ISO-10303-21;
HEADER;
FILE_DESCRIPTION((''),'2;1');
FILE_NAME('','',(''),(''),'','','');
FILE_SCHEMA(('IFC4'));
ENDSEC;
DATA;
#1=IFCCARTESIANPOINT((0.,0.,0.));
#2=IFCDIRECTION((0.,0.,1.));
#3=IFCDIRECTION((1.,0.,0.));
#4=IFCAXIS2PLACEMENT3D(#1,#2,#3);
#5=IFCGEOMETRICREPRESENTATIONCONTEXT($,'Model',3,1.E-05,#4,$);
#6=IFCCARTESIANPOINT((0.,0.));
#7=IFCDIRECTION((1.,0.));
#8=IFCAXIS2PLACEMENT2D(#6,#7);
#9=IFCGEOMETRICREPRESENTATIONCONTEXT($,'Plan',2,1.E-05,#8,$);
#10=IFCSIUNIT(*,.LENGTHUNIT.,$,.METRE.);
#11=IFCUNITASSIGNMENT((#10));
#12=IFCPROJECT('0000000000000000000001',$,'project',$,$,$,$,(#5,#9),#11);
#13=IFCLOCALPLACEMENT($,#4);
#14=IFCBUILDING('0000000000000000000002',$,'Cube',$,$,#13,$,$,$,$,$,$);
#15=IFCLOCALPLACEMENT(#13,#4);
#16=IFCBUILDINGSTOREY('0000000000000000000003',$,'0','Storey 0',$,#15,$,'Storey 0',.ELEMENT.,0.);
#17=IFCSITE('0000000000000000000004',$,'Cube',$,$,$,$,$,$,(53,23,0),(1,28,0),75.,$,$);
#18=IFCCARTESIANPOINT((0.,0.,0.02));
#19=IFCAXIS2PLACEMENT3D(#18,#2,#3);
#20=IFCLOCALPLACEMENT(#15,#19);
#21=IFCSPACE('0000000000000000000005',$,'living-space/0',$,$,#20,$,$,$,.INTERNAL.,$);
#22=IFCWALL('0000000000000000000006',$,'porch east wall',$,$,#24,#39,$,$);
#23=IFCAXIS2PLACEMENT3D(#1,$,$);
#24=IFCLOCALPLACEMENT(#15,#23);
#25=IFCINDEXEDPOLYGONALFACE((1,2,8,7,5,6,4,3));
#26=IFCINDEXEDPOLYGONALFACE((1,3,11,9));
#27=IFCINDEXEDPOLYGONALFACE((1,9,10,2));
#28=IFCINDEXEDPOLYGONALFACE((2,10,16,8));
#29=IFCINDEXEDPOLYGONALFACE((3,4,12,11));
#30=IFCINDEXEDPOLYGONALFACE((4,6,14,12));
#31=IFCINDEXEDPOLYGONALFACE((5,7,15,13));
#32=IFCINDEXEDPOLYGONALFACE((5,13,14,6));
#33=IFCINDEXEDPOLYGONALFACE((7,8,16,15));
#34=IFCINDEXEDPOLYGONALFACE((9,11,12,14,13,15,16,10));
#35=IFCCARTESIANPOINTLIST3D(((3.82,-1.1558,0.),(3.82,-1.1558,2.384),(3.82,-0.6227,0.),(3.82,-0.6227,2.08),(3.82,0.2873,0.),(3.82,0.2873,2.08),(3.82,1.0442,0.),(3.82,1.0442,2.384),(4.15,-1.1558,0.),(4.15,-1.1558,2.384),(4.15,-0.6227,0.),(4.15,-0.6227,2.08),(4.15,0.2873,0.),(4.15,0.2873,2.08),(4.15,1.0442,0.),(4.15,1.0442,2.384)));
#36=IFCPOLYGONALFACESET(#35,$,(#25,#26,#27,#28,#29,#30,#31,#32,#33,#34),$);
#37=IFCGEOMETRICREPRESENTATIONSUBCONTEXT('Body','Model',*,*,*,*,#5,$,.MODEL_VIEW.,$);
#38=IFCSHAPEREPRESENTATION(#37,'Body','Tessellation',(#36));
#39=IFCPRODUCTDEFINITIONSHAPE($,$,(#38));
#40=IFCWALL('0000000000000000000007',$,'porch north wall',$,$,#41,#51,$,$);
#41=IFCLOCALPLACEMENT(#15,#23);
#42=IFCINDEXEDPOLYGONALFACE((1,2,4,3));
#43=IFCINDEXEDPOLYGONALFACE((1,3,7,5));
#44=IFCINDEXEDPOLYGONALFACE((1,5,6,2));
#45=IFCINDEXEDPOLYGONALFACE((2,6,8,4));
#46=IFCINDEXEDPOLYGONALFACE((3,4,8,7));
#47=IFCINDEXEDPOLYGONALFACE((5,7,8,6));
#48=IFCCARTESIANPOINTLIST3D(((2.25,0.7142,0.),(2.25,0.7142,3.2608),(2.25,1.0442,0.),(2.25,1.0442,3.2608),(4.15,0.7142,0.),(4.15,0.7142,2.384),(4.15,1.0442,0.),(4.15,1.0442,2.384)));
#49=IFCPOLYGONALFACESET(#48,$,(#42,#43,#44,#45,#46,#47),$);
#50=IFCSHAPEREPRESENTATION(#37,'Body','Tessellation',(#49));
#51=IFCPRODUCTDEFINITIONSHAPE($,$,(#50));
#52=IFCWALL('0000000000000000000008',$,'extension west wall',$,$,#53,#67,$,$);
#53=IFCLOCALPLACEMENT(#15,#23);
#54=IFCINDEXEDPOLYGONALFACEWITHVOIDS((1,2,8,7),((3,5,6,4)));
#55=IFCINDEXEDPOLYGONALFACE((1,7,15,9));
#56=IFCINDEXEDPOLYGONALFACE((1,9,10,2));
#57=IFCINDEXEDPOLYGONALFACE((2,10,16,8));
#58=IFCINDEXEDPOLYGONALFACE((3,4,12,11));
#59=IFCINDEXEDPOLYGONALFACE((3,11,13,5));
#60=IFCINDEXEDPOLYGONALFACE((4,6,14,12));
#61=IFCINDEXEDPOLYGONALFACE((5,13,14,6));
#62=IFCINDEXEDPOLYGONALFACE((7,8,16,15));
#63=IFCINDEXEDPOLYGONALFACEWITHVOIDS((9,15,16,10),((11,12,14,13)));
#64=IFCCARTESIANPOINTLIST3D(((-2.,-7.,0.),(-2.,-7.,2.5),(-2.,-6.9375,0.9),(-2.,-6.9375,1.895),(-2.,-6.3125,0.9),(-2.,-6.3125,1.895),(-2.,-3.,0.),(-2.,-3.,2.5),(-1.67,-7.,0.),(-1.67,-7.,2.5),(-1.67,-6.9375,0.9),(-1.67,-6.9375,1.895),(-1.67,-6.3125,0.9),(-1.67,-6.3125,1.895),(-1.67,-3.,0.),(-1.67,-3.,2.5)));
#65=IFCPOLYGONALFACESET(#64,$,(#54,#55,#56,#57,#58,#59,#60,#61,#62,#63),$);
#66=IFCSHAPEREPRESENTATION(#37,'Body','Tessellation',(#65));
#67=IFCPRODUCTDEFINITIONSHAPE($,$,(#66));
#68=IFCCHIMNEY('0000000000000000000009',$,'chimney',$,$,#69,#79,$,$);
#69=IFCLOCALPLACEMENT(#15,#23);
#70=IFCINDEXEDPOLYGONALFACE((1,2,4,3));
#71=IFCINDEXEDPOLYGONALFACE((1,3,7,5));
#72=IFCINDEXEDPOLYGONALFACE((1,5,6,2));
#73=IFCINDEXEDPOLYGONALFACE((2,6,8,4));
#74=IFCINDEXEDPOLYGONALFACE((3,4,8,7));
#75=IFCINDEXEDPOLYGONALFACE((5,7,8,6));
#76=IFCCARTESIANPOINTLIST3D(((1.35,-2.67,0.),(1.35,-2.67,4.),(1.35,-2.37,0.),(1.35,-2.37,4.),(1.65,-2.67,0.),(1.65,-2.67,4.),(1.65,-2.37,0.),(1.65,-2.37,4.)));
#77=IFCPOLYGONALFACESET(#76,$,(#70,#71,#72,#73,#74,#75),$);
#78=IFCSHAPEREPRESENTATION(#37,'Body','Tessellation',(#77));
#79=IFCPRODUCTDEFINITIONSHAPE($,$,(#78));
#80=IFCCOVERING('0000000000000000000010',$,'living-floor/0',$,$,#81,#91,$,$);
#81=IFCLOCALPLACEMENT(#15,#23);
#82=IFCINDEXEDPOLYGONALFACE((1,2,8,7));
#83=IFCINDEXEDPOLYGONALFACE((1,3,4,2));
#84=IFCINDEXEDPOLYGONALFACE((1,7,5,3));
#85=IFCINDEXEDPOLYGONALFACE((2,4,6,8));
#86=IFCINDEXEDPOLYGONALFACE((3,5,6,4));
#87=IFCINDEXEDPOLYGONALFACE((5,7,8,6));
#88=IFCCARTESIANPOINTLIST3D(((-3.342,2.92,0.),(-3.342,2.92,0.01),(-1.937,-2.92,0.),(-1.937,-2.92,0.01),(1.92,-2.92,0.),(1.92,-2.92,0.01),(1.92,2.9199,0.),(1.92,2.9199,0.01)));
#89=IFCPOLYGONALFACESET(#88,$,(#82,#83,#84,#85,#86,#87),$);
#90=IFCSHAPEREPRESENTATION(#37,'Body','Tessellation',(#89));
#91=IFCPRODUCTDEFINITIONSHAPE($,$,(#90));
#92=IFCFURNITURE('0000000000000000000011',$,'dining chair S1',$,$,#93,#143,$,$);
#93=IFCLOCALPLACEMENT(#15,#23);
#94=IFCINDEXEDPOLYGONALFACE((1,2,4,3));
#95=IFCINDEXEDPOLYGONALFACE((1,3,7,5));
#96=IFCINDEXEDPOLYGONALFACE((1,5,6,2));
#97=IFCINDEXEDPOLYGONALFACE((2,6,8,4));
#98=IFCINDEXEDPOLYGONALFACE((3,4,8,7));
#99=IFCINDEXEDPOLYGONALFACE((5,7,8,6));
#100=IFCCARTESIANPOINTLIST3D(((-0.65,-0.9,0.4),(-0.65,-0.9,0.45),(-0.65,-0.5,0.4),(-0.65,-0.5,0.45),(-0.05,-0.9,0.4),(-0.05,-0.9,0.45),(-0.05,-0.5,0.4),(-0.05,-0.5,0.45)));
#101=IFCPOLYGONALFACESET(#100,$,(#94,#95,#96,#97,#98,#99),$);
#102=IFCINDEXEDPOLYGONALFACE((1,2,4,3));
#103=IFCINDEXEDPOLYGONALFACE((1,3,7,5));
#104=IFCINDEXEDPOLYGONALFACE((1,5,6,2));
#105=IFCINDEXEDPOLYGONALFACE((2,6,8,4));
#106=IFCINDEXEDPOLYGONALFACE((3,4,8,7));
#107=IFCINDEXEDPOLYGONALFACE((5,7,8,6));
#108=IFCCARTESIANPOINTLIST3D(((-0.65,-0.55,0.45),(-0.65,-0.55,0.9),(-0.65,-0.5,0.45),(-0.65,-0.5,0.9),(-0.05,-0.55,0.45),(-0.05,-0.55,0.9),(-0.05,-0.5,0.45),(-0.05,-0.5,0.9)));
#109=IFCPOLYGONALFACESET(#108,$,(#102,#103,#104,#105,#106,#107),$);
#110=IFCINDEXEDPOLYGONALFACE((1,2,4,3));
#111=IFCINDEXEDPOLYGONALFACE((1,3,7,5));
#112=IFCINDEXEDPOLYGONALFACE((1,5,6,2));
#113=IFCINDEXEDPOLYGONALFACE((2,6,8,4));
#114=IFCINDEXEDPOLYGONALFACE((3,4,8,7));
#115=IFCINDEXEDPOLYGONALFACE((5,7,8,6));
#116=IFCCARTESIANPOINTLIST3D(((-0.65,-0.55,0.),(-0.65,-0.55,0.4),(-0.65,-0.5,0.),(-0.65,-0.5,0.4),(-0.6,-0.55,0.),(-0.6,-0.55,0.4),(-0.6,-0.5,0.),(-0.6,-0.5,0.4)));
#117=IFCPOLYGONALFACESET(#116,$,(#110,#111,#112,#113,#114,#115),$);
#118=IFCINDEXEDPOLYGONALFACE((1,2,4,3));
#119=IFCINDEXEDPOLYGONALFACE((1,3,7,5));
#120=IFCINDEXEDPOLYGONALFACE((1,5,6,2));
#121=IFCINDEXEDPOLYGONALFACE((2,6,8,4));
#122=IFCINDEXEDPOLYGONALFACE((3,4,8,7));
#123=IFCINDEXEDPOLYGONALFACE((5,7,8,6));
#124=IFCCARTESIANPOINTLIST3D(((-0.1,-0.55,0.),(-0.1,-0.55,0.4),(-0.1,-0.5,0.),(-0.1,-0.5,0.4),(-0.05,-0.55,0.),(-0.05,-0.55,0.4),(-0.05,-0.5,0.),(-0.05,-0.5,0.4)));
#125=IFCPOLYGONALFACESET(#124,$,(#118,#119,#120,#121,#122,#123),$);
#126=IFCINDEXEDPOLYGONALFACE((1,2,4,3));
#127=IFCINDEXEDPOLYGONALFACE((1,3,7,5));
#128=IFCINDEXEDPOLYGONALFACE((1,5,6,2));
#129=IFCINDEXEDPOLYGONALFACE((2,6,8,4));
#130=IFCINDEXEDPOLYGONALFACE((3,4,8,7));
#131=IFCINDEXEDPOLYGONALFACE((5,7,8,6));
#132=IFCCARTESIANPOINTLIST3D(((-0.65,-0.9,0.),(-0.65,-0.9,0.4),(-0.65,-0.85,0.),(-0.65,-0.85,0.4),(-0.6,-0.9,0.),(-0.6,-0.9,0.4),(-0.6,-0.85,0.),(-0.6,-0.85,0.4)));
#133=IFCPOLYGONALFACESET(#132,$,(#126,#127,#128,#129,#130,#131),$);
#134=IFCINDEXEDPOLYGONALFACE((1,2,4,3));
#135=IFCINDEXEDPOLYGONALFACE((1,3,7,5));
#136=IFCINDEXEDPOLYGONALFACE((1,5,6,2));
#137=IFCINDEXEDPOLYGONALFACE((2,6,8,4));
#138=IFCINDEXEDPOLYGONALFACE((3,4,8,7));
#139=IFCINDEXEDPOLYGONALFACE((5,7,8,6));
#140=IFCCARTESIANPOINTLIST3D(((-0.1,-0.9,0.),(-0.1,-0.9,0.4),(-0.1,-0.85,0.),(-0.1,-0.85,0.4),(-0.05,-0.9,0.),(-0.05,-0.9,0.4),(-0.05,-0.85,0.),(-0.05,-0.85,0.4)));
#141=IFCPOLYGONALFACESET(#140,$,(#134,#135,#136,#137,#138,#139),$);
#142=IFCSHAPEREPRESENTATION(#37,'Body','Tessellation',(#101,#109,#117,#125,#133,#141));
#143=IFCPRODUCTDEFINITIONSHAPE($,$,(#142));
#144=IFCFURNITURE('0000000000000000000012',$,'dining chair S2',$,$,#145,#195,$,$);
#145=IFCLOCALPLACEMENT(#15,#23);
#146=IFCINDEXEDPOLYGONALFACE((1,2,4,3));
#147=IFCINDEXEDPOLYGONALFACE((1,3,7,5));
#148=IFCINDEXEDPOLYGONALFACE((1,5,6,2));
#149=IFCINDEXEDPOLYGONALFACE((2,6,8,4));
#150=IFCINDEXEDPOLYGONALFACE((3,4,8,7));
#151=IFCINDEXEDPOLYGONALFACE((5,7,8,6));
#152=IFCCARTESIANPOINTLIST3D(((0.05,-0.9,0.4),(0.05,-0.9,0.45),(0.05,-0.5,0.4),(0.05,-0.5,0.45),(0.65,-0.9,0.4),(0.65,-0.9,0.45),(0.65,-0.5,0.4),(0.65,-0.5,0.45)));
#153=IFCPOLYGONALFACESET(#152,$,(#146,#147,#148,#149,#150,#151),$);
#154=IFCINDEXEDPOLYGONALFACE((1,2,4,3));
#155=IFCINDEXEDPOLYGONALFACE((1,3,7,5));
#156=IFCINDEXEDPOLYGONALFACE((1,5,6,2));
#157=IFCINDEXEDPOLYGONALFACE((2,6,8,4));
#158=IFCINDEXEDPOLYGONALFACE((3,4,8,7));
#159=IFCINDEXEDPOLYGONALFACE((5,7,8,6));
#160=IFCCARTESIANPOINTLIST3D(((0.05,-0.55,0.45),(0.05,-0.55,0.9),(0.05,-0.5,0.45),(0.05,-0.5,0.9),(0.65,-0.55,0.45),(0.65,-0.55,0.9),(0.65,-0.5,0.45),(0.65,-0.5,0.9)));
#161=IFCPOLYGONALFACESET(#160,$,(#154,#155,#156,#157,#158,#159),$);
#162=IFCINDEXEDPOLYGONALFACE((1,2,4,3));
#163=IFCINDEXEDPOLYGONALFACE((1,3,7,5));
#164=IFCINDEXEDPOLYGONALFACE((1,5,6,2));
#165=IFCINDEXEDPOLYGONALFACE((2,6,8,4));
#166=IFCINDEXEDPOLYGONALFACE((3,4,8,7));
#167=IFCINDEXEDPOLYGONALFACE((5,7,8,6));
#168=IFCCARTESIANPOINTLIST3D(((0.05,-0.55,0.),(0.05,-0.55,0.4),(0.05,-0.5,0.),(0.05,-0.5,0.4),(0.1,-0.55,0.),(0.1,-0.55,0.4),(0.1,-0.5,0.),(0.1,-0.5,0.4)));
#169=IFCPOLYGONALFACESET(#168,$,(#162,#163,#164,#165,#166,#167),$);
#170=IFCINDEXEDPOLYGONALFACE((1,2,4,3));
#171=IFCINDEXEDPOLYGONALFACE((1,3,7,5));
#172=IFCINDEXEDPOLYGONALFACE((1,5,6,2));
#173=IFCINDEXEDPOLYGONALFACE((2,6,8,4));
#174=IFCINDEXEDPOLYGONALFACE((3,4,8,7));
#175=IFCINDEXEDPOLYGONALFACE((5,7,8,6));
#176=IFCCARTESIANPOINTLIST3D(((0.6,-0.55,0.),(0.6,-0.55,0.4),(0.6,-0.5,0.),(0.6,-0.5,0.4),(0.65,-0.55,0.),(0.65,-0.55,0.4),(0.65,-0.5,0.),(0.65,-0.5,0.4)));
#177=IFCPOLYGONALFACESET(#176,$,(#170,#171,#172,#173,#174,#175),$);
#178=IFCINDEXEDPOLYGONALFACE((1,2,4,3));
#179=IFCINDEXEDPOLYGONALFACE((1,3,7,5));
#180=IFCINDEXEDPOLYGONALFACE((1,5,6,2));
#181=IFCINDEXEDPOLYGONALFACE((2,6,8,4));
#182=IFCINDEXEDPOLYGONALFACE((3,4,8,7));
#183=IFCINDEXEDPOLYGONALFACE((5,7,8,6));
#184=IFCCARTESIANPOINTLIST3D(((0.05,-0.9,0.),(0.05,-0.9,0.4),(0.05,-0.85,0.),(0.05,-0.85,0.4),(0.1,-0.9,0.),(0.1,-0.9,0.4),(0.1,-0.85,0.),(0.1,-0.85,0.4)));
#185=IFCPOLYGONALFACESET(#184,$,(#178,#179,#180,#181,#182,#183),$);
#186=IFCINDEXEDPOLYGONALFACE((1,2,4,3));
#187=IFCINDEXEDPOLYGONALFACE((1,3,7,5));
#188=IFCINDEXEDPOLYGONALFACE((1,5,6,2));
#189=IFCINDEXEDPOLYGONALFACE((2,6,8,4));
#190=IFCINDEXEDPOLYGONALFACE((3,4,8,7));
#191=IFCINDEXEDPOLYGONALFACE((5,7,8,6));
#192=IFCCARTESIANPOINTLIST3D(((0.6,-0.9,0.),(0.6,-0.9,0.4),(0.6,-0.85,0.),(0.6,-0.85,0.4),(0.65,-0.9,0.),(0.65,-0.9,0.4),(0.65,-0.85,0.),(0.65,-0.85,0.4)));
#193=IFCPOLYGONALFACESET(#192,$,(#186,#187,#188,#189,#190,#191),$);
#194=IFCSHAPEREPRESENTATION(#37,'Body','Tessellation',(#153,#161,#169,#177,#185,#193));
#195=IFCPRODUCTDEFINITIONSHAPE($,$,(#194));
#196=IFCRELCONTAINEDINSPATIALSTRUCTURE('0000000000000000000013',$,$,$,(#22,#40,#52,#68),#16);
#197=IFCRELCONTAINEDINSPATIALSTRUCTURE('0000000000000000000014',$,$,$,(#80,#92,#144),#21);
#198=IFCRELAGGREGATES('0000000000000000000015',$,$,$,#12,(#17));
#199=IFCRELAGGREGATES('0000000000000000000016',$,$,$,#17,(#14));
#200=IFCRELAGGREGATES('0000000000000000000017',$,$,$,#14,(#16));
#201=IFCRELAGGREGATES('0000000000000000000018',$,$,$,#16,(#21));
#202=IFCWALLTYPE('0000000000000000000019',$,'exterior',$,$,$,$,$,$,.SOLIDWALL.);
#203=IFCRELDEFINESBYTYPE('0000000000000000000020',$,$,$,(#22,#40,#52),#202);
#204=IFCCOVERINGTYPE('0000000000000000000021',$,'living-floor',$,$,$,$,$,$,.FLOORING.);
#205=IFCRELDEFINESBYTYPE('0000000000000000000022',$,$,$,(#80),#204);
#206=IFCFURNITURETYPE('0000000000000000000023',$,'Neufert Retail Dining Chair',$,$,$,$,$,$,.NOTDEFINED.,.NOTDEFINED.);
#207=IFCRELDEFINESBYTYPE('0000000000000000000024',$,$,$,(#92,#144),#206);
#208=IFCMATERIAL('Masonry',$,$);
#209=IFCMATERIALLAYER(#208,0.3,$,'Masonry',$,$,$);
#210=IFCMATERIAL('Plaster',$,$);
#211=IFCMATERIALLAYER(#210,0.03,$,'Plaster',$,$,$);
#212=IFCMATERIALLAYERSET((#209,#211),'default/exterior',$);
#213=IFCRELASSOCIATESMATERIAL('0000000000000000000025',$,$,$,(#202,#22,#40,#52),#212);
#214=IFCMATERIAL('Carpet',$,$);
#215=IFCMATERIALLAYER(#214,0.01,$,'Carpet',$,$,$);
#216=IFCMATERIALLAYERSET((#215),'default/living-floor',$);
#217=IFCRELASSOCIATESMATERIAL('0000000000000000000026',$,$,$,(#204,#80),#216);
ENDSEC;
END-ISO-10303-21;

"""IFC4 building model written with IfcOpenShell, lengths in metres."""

from ifc_helpers import new_model, entity, si_unit, frame, origin_with_axes, origin_2d_with_axis, place, context, subcontext, project, spatial, polyline, line, indexed_curve, outline, extrude, clip, halfspace, shape, source, transform, mapped, material, layer, layer_set, layer_usage, type_object, type_shapes, element, save


model = new_model("IFC4")

# Units and contexts
model_context = context("Model", 3, precision=1e-05, world=origin_with_axes())
plan_context = context("Plan", 2, precision=1e-05, world=origin_2d_with_axis())
body_context_1 = subcontext(model_context, "Body", "Model", "MODEL_VIEW")
body_context_2 = subcontext(plan_context, "Body", "Plan", "PLAN_VIEW")
ifc_project = project(units=[si_unit("LENGTHUNIT", "METRE")], contexts=[model_context, plan_context])

# Site, building, storey
site = spatial("IfcSite", under=ifc_project, Name="Cube", RefLatitude=(53, 23, 0), RefLongitude=(1, 28, 0), RefElevation=75.0)
building_placement = place(None, origin_with_axes())
building = spatial("IfcBuilding", under=site, at=building_placement, Name="Cube")
storey_placement = place(building_placement, origin_with_axes())
storey = spatial("IfcBuildingStorey", under=building, at=storey_placement, Name="0", Description="Storey 0", LongName="Storey 0", CompositionType="ELEMENT", Elevation=0.0)

# Shared definitions
ifc_material_1 = material(Name="Masonry")
ifc_layer_1 = layer(ifc_material_1, 0.3, Name="Masonry")
ifc_material_2 = material(Name="Plaster")
ifc_layer_2 = layer(ifc_material_2, 0.03, Name="Plaster")
ifc_layer_set_1 = layer_set([ifc_layer_1, ifc_layer_2], Name="default/exterior")
wall_type = type_object("IfcWallType", Name="exterior", PredefinedType="SOLIDWALL", material=ifc_layer_set_1)

# Wall, opening
ifc_layer_usage_1 = layer_usage(ifc_layer_set_1, "AXIS2", "POSITIVE", 0.0)
wall_1_placement = place(storey_placement, frame((4.15, -1.1558, 0.0), z_axis=(0.0, 0.0, 1.0), x_axis=(0.0, 1.0, 0.0)))
wall_1 = element("IfcWall", 1, at=wall_1_placement, inside=storey, type_object=wall_type, material=ifc_layer_usage_1, Name="porch east wall", context=body_context_1, shape_type="SweptSolid", body=[
    extrude(outline(indexed_curve([(0.0, 0.0), (0.0, 0.33), (2.2, 0.33), (2.2, 0.0), (0.0, 0.0)], self_intersect=False)), origin_with_axes(), (0.0, 0.0, 1.0), 2.384),
])
shared_shape_1 = source(origin_with_axes(), body_context_1, "Body", "SweptSolid", [
    extrude(outline(indexed_curve([(0.0, 0.0), (0.91, 0.0), (0.91, 2.08), (0.0, 2.08)], segments=[line(1, 2, 3, 4, 1)])), frame((0.0, -0.6, 0.0), z_axis=(0.0, -1.0, 0.0), x_axis=(1.0, 0.0, 0.0)), (0.0, 0.0, -1.0), 1.2),
])
opening_1_placement = place(wall_1_placement, frame((0.5331, 0.0, 0.0), z_axis=(0.0, 0.0, 1.0), x_axis=(1.0, 0.0, 0.0)))
element("IfcOpeningElement", 2, at=opening_1_placement, cuts=wall_1, PredefinedType="OPENING", context=body_context_1, shape_type="MappedRepresentation", body=[
    mapped(shared_shape_1, transform((0.0, 0.0, 0.0), x_axis=(1.0, 0.0, 0.0), y_axis=(0.0, 1.0, 0.0), z_axis=(0.0, 0.0, 1.0), scale=1.0)),
])

# Wall
ifc_layer_usage_2 = layer_usage(ifc_layer_set_1, "AXIS2", "POSITIVE", 0.0)
wall_2_placement = place(storey_placement, frame((4.15, 1.0442, 0.0), z_axis=(0.0, 0.0, 1.0), x_axis=(-1.0, 0.0, 0.0)))
element("IfcWall", 3, at=wall_2_placement, inside=storey, type_object=wall_type, material=ifc_layer_usage_2, Name="porch north wall", context=body_context_1, shape_type="Clipping", body=[
    clip(extrude(outline(indexed_curve([(0.0, 0.0), (0.0, 0.33), (1.9, 0.33), (1.9, 0.0), (0.0, 0.0)], self_intersect=False)), origin_with_axes(), (0.0, 0.0, 1.0), 3.5), halfspace(frame((0.0, 0.0, 2.384), z_axis=(-0.419, 0.0, 0.908), x_axis=(0.0, -1.0, 0.0)), False)),
])

# Wall, opening
ifc_layer_usage_3 = layer_usage(ifc_layer_set_1, "AXIS2", "POSITIVE", 0.0)
wall_3_placement = place(storey_placement, frame((-2.0, -3.0, 0.0), z_axis=(0.0, 0.0, 1.0), x_axis=(0.0, -1.0, 0.0)))
wall_3 = element("IfcWall", 4, at=wall_3_placement, inside=storey, type_object=wall_type, material=ifc_layer_usage_3, Name="extension west wall", context=body_context_1, shape_type="SweptSolid", body=[
    extrude(outline(indexed_curve([(0.0, 0.0), (0.0, 0.33), (4.0, 0.33), (4.0, 0.0), (0.0, 0.0)], self_intersect=False)), origin_with_axes(), (0.0, 0.0, 1.0), 2.5),
])
opening_2_placement = place(wall_3_placement, frame((3.3125, 0.0, 0.9), z_axis=(0.0, 0.0, 1.0), x_axis=(1.0, 0.0, 0.0)))
element("IfcOpeningElement", 5, at=opening_2_placement, cuts=wall_3, PredefinedType="OPENING", context=body_context_1, shape_type="SweptSolid", body=[
    extrude(outline(indexed_curve([(0.0, 0.0), (0.0, 0.5), (0.625, 0.5), (0.625, 0.0), (0.0, 0.0)], self_intersect=False)), origin_with_axes(), (0.0, 0.0, 1.0), 0.995),
])

# Chimney
chimney_placement = place(storey_placement, frame((1.35, -2.67, 0.0), z_axis=(0.0, 0.0, 1.0), x_axis=(1.0, 0.0, 0.0)))
element("IfcChimney", 6, at=chimney_placement, inside=storey, Name="chimney", context=body_context_1, shape_type="SweptSolid", body=[
    extrude(outline(indexed_curve([(0.0, 0.0), (0.3, 0.0), (0.3, 0.3), (0.0, 0.3)])), None, (0.0, 0.0, 1.0), 4.0),
])

# Shared definitions
space_placement = place(storey_placement, frame((0.0, 0.0, 0.02), z_axis=(0.0, 0.0, 1.0), x_axis=(1.0, 0.0, 0.0)))
space = spatial("IfcSpace", under=storey, at=space_placement, Name="living-space/0", PredefinedType="INTERNAL")

# Covering
ifc_material_3 = material(Name="Carpet")
ifc_layer_3 = layer(ifc_material_3, 0.01, Name="Carpet")
ifc_layer_set_2 = layer_set([ifc_layer_3], Name="default/living-floor")
ifc_layer_usage_4 = layer_usage(ifc_layer_set_2, "AXIS3", "POSITIVE", 0.0)
covering_type = type_object("IfcCoveringType", Name="living-floor", PredefinedType="FLOORING", material=ifc_layer_set_2)
covering_placement = place(space_placement, frame((0.0, 0.0, -0.02), z_axis=(0.0, 0.0, 1.0), x_axis=(1.0, 0.0, 0.0)))
element("IfcCovering", 7, at=covering_placement, inside=space, type_object=covering_type, material=ifc_layer_usage_4, Name="living-floor/0", context=body_context_1, shape_type="SweptSolid", body=[
    extrude(outline(polyline([(1.92, 2.9199), (-3.342, 2.92), (-1.937, -2.92), (1.92, -2.92), (1.92, 2.9199)])), origin_with_axes(), (0.0, 0.0, 1.0), 0.01),
])

# Furniture
furniture_type_1 = type_object("IfcFurnitureType", Name="Neufert Retail Dining Chair", AssemblyPlace="NOTDEFINED", PredefinedType="NOTDEFINED")
shared_shape_2 = source(origin_with_axes(), body_context_1, "Body", "SweptSolid", [
    extrude(outline(indexed_curve([(-0.3, 0.0), (0.3, 0.0), (0.3, -0.4), (-0.3, -0.4)], segments=[line(1, 2, 3, 4, 1)])), frame((0.0, 0.0, 0.45), z_axis=(0.0, 0.0, 1.0), x_axis=(1.0, 0.0, 0.0)), (0.0, 0.0, -1.0), 0.05),
    extrude(outline(indexed_curve([(-0.3, 0.0), (0.3, 0.0), (0.3, -0.05), (-0.3, -0.05)], segments=[line(1, 2, 3, 4, 1)])), frame((0.0, 0.0, 0.9), z_axis=(0.0, 0.0, 1.0), x_axis=(1.0, 0.0, 0.0)), (0.0, 0.0, -1.0), 0.45),
    extrude(outline(indexed_curve([(-0.3, 0.0), (-0.25, 0.0), (-0.25, -0.05), (-0.3, -0.05)], segments=[line(1, 2, 3, 4, 1)])), origin_with_axes(), (0.0, 0.0, 1.0), 0.4),
    extrude(outline(indexed_curve([(0.3, 0.0), (0.25, 0.0), (0.25, -0.05), (0.3, -0.05)], segments=[line(1, 2, 3, 4, 1)])), origin_with_axes(), (0.0, 0.0, 1.0), 0.4),
    extrude(outline(indexed_curve([(-0.3, -0.4), (-0.25, -0.4), (-0.25, -0.35), (-0.3, -0.35)], segments=[line(1, 2, 3, 4, 1)])), origin_with_axes(), (0.0, 0.0, 1.0), 0.4),
    extrude(outline(indexed_curve([(0.3, -0.4), (0.25, -0.4), (0.25, -0.35), (0.3, -0.35)], segments=[line(1, 2, 3, 4, 1)])), origin_with_axes(), (0.0, 0.0, 1.0), 0.4),
])
shared_shape_3 = source(origin_with_axes(), body_context_2, "Body", "Curve2D", [
    entity("IfcIndexedPolyCurve", entity("IfcCartesianPointList2D", [[-0.3, -0.4], [0.3, -0.4]])),
    entity("IfcIndexedPolyCurve", entity("IfcCartesianPointList2D", [[-0.3, -0.4], [-0.3, -0.3], [-0.2121, -0.0879], [0.0, 0.0], [0.2121, -0.0879], [0.3, -0.3], [0.3, -0.4]]), [entity("IfcLineIndex", [1, 2]), entity("IfcArcIndex", [2, 3, 4]), entity("IfcArcIndex", [4, 5, 6]), entity("IfcLineIndex", [6, 7])]),
    entity("IfcIndexedPolyCurve", entity("IfcCartesianPointList2D", [[-0.26, -0.4], [-0.26, -0.3], [-0.1838, -0.1162], [0.0, -0.04], [0.1838, -0.1162], [0.26, -0.3], [0.26, -0.4]]), [entity("IfcLineIndex", [1, 2]), entity("IfcArcIndex", [2, 3, 4]), entity("IfcArcIndex", [4, 5, 6]), entity("IfcLineIndex", [6, 7])]),
])
type_shapes(furniture_type_1, [shared_shape_2, shared_shape_3])
for number, where, z_axis, x_axis, name in (
    (8, (-0.35, -0.5, -0.02), (0.0, 0.0, 1.0), (1.0, 0.0, 0.0), "dining chair S1"),
    (9, (0.35, -0.5, -0.02), (0.0, 0.0, 1.0), (1.0, 0.0, 0.0), "dining chair S2"),
):
    element("IfcFurniture", number, at=place(space_placement, frame(where, z_axis=z_axis, x_axis=x_axis)), inside=space, type_object=furniture_type_1, Name=name, shapes=[
        shape(body_context_1, "Body", "MappedRepresentation", [mapped(shared_shape_2, transform((0.0, 0.0, 0.0), x_axis=(1.0, 0.0, 0.0), y_axis=(0.0, 1.0, 0.0), z_axis=(0.0, 0.0, 1.0), scale=1.0))]),
        shape(body_context_2, "Body", "MappedRepresentation", [mapped(shared_shape_3, transform((0.0, 0.0, 0.0), x_axis=(1.0, 0.0, 0.0), y_axis=(0.0, 1.0, 0.0), z_axis=(0.0, 0.0, 1.0), scale=1.0))]),
    ])

save(model, "model.ifc")
